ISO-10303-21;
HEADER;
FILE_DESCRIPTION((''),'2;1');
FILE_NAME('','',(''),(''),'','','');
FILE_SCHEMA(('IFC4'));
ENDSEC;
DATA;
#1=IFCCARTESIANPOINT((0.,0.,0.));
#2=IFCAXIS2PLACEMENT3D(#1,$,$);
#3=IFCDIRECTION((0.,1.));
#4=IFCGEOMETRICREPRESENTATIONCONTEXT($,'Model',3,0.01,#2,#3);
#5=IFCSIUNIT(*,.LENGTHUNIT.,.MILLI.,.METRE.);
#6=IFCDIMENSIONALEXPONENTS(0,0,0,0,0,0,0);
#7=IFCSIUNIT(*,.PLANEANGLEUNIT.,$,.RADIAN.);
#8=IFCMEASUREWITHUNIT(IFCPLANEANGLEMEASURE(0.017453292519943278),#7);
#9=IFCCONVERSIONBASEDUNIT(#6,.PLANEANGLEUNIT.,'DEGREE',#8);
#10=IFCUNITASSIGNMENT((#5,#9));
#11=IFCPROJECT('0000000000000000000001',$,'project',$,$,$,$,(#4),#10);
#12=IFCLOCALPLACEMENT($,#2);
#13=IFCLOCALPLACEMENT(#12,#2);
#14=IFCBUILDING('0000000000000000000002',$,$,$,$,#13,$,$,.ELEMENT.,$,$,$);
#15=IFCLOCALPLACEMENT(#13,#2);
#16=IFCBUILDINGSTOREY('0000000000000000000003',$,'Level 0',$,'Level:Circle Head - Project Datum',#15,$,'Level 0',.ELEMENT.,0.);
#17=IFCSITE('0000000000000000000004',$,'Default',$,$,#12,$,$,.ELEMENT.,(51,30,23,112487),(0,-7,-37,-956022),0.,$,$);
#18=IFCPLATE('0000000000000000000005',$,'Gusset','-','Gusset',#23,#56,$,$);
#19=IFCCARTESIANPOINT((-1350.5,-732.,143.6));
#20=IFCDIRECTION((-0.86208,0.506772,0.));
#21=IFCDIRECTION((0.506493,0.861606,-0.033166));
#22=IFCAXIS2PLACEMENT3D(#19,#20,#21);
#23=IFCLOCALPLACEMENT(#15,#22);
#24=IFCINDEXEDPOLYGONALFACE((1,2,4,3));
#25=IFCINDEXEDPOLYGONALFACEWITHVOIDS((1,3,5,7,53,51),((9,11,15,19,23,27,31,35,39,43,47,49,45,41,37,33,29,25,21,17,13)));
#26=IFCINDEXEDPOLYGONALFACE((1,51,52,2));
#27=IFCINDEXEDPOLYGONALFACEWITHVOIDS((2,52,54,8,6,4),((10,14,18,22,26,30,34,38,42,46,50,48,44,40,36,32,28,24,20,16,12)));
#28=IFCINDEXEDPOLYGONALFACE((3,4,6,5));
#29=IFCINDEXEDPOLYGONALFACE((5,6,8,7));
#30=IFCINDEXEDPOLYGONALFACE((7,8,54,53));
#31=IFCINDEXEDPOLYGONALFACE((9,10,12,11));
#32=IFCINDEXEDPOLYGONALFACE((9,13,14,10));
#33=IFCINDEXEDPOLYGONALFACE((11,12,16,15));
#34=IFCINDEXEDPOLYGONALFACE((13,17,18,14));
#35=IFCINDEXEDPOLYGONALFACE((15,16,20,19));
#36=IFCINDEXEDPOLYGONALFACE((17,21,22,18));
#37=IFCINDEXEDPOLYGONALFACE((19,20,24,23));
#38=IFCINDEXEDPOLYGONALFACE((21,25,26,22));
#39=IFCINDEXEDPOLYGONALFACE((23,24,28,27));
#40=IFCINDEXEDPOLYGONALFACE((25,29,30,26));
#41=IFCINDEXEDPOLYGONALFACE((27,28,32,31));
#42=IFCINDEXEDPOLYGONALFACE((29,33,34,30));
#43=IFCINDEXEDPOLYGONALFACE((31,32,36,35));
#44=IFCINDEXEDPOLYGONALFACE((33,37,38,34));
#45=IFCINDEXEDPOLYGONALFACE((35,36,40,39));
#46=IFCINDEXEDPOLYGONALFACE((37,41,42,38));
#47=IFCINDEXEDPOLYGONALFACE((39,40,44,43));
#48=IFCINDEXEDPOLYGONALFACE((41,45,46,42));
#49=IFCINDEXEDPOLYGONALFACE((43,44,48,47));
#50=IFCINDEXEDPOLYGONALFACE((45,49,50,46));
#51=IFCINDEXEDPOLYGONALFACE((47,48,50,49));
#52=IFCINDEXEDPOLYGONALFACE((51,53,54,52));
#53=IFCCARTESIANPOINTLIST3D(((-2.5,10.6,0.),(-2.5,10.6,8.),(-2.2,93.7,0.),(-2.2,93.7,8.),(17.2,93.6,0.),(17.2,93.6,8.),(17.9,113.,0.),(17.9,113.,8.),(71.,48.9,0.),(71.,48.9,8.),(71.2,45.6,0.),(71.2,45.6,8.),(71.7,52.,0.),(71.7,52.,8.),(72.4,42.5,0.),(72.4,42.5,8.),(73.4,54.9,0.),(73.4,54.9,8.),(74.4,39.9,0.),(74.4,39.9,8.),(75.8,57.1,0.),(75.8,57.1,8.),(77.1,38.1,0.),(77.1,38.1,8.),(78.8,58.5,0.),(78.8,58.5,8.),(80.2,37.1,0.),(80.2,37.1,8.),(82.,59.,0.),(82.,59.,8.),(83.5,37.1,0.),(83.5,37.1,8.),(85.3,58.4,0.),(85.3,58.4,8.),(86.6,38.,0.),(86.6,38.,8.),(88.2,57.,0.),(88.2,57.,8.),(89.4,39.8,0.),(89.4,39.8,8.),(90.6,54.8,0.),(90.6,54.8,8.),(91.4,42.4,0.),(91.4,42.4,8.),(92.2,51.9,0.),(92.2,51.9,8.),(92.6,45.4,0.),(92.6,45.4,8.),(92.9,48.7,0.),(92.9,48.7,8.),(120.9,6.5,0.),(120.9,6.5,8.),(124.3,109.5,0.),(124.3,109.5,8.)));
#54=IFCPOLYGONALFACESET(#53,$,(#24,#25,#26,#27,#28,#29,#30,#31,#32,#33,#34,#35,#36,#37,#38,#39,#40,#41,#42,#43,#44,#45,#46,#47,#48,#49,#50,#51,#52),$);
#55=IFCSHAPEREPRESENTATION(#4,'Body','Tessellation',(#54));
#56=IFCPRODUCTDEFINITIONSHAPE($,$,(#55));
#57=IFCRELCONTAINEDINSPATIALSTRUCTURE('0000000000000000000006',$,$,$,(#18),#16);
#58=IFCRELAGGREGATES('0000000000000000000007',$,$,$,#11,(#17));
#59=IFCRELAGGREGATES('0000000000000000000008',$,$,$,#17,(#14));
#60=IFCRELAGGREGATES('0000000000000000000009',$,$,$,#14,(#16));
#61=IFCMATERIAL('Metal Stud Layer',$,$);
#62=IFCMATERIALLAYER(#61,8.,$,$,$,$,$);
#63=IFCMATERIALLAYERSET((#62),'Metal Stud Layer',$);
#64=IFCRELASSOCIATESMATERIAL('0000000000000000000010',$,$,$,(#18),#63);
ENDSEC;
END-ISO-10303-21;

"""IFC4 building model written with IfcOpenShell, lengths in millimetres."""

from ifc_helpers import new_model, entity, si_unit, converted_unit, point, direction, frame, frame_2d, origin, origin_with_axes, origin_2d_with_axis, place, context, project, spatial, polyline, circle_curve, line_curve, trimmed, segment, composite_curve, circle, outline, extrude, material, layer, layer_set, element, save


model = new_model("IFC4")

# Units and contexts
model_context = context("Model", 3, precision=0.01, world=origin(), true_north=direction((0.0, 1.0)))
ifc_project = project(units=[si_unit("LENGTHUNIT", "METRE", prefix="MILLI"), converted_unit("PLANEANGLEUNIT", "DEGREE", entity("IfcPlaneAngleMeasure", 0.017453292519943278), si_unit("PLANEANGLEUNIT", "RADIAN"), dimensions=[0, 0, 0, 0, 0, 0, 0])], contexts=[model_context])

# Site, building, storey
site_placement = place(None, origin())
site = spatial("IfcSite", under=ifc_project, at=site_placement, Name="Default", CompositionType="ELEMENT", RefLatitude=(51, 30, 23, 112487), RefLongitude=(0, -7, -37, -956022), RefElevation=0.0)
building_placement = place(site_placement, origin())
building = spatial("IfcBuilding", under=site, at=building_placement, CompositionType="ELEMENT")
storey_placement = place(building_placement, origin())
storey = spatial("IfcBuildingStorey", under=building, at=storey_placement, Name="Level 0", ObjectType="Level:Circle Head - Project Datum", LongName="Level 0", CompositionType="ELEMENT", Elevation=0.0)

# Plate, openings
ifc_material_1 = material(Name="Metal Stud Layer")
ifc_layer_1 = layer(ifc_material_1, 8.0)
ifc_layer_set_1 = layer_set([ifc_layer_1], Name="Metal Stud Layer")
plate_1_placement = place(storey_placement, frame((-1350.5, -732.0, 143.6), z_axis=(-0.86208, 0.506772, 0.0), x_axis=(0.506493, 0.861606, -0.033166)))
plate_1 = element("IfcPlate", 1, at=plate_1_placement, inside=storey, material=ifc_layer_set_1, Name="Gusset", Description="-", ObjectType="Gusset", context=model_context, shape_type="SweptSolid", body=[
    extrude(outline(polyline([(120.9, 6.5), (124.3, 109.5), (17.9, 113.0), (17.2, 93.6), (-2.2, 93.7), (-2.5, 10.6), (120.9, 6.5)])), origin_with_axes(), (0.0, 0.0, 1.0), 8.0),
])
opening_1_placement = place(plate_1_placement, origin_with_axes())
element("IfcOpeningElement", 2, at=opening_1_placement, cuts=plate_1, ObjectType="Opening", context=model_context, shape_type="SweptSolid", body=[
    extrude(outline(composite_curve([segment(trimmed(line_curve((17.2, 93.6), (-0.999992, 0.004054), 19.425957), [point((17.2, 93.6))], [point((-2.2, 93.7))], True, "CARTESIAN"), True, "CONTINUOUS"), segment(trimmed(circle_curve(frame_2d((-2.1, 113.7), x_axis=(1.0, 0.0)), 20.0), [point((-2.2, 93.7))], [point((17.9, 113.0))], True, "CARTESIAN"), True, "CONTINUOUS"), segment(trimmed(line_curve((17.9, 113.0), (-0.033166, -0.99945), 19.425957), [point((17.9, 113.0))], [point((17.2, 93.6))], True, "CARTESIAN"), True, "CONTINUOUS")], self_intersect="UNKNOWN")), origin(), (0.0, 0.0, 1.0), 8.0),
])
opening_2_placement = place(plate_1_placement, frame((81.9, 48.0, 8.5), z_axis=(0.0, 0.0, -1.0), x_axis=(0.862509, -0.506042, 0.0)))
element("IfcOpeningElement", 3, at=opening_2_placement, cuts=plate_1, ObjectType="Opening", context=model_context, shape_type="SweptSolid", body=[
    extrude(circle(Radius=11.0, at=origin_2d_with_axis()), origin(), (0.0, 0.0, 1.0), 9.0),
])

save(model, "model.ifc")
